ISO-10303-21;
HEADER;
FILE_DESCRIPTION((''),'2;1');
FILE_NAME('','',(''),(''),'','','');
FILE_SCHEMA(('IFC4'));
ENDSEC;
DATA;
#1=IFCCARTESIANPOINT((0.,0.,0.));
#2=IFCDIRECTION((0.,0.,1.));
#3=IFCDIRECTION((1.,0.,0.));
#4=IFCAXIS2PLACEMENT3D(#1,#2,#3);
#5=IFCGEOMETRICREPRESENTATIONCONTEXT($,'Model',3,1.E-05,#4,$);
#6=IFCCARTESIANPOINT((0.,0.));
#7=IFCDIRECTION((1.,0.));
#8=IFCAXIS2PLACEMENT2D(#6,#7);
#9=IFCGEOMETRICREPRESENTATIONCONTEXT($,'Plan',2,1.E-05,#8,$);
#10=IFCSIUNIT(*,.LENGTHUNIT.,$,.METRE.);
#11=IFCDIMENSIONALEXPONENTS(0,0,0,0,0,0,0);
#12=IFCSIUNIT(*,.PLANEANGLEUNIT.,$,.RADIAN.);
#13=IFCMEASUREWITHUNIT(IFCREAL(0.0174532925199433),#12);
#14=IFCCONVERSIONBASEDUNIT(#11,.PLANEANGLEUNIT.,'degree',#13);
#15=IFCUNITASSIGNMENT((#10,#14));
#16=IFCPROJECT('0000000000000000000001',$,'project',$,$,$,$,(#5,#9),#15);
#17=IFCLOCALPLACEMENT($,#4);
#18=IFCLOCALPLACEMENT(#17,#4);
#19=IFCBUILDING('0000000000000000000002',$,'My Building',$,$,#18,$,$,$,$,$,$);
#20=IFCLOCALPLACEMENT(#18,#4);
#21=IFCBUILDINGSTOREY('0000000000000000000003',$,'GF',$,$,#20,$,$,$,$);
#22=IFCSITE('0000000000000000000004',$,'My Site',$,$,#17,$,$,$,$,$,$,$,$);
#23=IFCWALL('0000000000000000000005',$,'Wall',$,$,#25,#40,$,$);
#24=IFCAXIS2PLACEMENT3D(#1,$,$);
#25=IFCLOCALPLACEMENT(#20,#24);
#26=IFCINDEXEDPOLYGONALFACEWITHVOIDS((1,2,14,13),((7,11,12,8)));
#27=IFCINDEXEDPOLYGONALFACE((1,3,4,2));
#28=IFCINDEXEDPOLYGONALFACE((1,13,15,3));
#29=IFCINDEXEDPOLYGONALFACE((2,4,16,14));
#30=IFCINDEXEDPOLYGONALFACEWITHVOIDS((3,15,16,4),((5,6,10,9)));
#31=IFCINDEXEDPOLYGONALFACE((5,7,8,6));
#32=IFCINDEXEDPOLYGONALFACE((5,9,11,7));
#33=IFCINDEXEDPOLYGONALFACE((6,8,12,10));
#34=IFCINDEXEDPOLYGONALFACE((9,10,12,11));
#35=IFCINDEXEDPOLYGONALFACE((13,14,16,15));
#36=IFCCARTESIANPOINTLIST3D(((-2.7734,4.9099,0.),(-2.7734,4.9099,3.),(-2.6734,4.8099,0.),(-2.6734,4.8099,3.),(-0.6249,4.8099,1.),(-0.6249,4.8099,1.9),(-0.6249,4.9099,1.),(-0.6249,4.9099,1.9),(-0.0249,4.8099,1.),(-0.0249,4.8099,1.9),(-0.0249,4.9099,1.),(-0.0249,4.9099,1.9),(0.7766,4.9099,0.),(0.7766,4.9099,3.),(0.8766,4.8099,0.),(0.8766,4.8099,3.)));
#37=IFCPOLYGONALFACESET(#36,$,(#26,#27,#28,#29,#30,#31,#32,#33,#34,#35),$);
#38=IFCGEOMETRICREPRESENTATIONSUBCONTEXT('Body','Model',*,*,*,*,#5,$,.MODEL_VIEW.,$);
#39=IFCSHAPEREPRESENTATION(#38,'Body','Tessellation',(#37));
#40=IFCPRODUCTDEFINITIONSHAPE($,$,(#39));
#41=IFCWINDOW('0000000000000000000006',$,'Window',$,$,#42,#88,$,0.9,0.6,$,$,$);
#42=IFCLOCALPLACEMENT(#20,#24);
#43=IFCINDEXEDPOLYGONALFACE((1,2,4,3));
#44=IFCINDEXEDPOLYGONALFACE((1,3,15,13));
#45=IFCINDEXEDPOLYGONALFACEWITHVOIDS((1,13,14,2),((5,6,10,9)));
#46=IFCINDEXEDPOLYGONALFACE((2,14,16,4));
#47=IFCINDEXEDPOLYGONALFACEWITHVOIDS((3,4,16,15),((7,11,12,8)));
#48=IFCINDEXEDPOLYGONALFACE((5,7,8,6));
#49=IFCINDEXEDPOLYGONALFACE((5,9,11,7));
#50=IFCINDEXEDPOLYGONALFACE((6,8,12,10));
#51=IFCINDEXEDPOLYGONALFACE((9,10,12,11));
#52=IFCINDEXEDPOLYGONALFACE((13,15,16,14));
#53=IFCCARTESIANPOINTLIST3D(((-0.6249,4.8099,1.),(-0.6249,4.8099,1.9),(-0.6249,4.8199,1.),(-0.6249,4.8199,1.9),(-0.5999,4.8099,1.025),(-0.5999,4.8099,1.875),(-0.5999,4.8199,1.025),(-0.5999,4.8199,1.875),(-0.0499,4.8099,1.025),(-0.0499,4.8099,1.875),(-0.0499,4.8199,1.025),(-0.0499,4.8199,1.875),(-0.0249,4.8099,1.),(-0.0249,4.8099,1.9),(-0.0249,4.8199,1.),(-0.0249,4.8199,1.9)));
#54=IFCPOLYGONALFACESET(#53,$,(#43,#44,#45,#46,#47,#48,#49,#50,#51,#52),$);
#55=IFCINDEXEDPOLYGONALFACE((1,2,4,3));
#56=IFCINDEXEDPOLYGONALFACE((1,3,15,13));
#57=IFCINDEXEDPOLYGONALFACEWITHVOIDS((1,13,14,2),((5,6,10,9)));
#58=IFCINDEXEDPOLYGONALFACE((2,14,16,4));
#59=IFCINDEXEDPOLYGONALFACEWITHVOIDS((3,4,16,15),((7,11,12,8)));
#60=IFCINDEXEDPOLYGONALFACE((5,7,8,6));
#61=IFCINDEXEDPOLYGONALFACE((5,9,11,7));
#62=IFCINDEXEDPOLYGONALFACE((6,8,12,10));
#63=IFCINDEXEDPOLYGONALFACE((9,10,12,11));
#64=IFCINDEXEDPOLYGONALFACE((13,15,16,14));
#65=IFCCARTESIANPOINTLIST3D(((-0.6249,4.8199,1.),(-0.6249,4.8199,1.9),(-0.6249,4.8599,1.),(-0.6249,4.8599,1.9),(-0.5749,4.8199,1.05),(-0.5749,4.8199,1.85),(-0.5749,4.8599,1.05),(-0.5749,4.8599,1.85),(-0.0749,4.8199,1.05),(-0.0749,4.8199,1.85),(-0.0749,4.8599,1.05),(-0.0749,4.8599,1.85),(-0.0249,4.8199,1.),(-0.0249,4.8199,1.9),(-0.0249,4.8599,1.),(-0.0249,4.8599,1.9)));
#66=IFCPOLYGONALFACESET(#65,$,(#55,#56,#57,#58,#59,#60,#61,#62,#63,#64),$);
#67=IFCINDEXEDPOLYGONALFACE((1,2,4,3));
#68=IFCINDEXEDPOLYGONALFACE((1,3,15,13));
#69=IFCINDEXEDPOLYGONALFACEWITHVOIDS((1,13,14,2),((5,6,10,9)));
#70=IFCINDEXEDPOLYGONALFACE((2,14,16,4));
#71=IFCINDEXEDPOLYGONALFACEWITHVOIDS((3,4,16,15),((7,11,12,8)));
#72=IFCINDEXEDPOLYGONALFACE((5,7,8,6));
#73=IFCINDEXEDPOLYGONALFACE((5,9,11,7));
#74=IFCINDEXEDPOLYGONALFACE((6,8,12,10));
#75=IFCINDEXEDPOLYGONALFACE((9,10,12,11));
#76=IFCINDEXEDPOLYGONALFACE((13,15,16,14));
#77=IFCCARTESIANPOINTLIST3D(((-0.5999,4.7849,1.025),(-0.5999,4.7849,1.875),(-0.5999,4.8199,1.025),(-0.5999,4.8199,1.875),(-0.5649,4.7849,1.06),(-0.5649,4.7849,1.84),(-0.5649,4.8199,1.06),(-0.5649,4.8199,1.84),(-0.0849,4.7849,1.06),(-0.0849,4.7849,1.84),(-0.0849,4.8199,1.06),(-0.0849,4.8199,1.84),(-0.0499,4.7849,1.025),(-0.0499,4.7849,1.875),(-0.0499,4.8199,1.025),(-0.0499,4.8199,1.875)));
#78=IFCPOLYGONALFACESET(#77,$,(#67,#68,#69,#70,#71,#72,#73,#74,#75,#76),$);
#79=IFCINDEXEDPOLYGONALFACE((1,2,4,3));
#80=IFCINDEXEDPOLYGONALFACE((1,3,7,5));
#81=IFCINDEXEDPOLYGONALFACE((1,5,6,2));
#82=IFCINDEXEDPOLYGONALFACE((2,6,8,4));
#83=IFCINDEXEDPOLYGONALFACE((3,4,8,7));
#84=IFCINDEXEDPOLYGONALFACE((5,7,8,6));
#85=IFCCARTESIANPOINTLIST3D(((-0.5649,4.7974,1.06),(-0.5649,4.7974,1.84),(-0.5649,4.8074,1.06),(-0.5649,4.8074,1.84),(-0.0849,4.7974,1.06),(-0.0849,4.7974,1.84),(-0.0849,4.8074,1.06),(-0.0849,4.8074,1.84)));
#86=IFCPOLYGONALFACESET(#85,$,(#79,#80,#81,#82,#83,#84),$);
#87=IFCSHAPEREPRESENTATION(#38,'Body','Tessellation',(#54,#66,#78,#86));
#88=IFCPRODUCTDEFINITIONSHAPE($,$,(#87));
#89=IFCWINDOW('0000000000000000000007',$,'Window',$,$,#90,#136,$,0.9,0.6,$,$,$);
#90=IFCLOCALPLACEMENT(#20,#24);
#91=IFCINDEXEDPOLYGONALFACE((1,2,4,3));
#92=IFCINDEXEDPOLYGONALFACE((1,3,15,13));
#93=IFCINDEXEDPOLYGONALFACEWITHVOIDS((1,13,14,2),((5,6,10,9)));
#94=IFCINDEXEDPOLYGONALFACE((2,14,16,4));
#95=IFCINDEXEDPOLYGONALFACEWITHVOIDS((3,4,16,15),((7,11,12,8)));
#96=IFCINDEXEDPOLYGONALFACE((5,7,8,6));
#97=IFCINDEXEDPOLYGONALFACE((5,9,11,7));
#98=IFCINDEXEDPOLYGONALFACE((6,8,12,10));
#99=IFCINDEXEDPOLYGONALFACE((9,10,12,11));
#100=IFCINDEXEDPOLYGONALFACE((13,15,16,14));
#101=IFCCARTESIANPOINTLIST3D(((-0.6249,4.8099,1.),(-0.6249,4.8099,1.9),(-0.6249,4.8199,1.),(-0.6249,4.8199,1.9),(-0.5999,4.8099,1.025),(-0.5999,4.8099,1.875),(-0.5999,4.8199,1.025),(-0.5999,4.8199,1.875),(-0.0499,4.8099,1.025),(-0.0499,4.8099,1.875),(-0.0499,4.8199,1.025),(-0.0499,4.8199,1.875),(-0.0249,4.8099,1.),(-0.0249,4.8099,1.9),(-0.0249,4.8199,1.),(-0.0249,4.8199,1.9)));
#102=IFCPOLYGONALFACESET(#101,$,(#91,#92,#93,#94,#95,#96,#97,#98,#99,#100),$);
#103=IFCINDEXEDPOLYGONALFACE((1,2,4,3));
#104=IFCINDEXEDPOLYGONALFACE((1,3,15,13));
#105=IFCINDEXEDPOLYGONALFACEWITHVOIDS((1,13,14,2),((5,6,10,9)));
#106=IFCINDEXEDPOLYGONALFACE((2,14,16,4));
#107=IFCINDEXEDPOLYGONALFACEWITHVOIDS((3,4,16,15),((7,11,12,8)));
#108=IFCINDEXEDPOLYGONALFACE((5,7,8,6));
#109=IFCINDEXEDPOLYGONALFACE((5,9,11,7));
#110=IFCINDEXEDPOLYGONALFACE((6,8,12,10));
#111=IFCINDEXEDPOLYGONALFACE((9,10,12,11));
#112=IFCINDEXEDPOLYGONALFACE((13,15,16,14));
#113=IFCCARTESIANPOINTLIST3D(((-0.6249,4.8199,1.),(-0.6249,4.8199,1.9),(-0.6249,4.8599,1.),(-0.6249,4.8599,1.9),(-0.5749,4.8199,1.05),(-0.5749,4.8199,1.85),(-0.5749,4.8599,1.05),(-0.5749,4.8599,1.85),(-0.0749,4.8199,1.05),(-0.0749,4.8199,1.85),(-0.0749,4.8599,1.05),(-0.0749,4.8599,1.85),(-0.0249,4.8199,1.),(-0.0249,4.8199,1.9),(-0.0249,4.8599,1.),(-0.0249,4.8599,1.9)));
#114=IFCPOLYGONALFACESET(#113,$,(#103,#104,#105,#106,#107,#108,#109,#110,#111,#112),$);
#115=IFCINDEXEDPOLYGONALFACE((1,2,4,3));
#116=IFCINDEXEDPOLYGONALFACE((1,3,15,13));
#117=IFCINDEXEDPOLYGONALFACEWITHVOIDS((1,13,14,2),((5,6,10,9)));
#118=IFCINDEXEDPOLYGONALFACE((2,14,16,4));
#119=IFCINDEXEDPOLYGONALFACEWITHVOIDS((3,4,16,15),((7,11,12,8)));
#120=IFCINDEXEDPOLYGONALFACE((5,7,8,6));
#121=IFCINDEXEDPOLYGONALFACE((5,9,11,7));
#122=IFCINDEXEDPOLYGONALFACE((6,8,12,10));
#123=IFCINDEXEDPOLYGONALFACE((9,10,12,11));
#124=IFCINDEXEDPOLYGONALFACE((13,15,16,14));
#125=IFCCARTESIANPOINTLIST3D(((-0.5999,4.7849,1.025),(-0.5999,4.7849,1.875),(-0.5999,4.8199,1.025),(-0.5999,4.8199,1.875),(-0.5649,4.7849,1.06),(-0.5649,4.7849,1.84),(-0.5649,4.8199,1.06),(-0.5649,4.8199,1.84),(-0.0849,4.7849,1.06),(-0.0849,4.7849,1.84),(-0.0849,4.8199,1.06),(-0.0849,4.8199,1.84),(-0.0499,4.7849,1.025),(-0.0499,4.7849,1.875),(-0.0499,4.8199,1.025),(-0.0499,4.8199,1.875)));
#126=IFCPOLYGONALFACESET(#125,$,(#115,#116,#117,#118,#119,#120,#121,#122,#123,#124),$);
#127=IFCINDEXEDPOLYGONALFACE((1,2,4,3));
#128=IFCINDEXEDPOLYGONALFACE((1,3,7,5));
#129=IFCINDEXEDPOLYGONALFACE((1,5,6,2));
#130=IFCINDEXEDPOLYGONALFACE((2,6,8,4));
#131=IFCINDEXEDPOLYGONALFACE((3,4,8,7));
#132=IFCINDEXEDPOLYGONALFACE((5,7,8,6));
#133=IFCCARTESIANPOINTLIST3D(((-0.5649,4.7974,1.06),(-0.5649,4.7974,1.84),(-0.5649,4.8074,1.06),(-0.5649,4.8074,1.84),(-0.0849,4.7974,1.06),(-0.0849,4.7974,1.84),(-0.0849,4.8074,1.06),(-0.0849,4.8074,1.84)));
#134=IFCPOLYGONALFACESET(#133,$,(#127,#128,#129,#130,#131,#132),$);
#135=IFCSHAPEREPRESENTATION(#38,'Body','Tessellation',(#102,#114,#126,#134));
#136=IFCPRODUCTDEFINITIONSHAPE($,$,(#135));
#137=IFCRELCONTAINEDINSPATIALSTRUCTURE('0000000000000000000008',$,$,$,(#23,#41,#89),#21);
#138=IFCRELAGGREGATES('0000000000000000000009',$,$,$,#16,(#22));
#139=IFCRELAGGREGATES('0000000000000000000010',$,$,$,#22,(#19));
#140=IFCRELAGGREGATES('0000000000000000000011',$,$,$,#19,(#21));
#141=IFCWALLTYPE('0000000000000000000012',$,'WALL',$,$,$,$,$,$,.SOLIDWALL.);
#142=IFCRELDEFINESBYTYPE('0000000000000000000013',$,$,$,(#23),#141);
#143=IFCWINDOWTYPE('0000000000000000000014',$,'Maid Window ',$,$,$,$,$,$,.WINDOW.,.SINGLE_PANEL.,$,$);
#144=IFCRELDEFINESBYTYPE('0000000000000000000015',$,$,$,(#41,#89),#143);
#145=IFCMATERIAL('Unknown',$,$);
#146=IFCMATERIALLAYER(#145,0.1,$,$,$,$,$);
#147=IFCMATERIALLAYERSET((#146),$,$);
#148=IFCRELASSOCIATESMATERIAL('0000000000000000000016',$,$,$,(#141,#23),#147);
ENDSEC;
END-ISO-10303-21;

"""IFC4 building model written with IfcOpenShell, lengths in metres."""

from ifc_helpers import new_model, entity, si_unit, converted_unit, frame, origin_with_axes, origin_2d_with_axis, place, context, subcontext, project, spatial, line, indexed_curve, outline, extrude, shape, source, transform, mapped, material, layer, layer_set, layer_usage, type_object, type_shapes, element, fill, save


model = new_model("IFC4")

# Units and contexts
model_context = context("Model", 3, precision=1e-05, world=origin_with_axes())
plan_context = context("Plan", 2, precision=1e-05, world=origin_2d_with_axis())
body_context_1 = subcontext(model_context, "Body", "Model", "MODEL_VIEW")
body_context_2 = subcontext(plan_context, "Body", "Plan", "PLAN_VIEW")
ifc_project = project(units=[si_unit("LENGTHUNIT", "METRE"), converted_unit("PLANEANGLEUNIT", "degree", entity("IfcReal", 0.0174532925199433), si_unit("PLANEANGLEUNIT", "RADIAN"), dimensions=[0, 0, 0, 0, 0, 0, 0])], contexts=[model_context, plan_context])

# Site, building, storey
site_placement = place(None, origin_with_axes())
site = spatial("IfcSite", under=ifc_project, at=site_placement, Name="My Site")
building_placement = place(site_placement, origin_with_axes())
building = spatial("IfcBuilding", under=site, at=building_placement, Name="My Building")
storey_placement = place(building_placement, origin_with_axes())
storey = spatial("IfcBuildingStorey", under=building, at=storey_placement, Name="GF")

# Shared definitions
ifc_material_1 = material(Name="Unknown")

# Shared definitions
ifc_layer_1 = layer(ifc_material_1, 0.1)
ifc_layer_set_1 = layer_set([ifc_layer_1])
wall_type = type_object("IfcWallType", Name="WALL", PredefinedType="SOLIDWALL", material=ifc_layer_set_1)

# Wall, openings, windows
ifc_layer_usage_1 = layer_usage(ifc_layer_set_1, "AXIS2", "POSITIVE", 0.0)
wall_1_placement = place(storey_placement, frame((0.7766, 4.9099, 0.0), z_axis=(0.0, 0.0, 1.0), x_axis=(-1.0, 0.0, 0.0)))
wall_1 = element("IfcWall", 1, at=wall_1_placement, inside=storey, type_object=wall_type, material=ifc_layer_usage_1, Name="Wall", context=body_context_1, shape_type="SweptSolid", body=[
    extrude(outline(indexed_curve([(0.0, 0.0), (-0.1, 0.1), (3.45, 0.1), (3.55, 0.0)], segments=[line(1, 2, 3, 4, 1)])), origin_with_axes(), (0.0, 0.0, 1.0), 3.0),
])
shared_shape_1 = source(origin_with_axes(), body_context_1, "Body", "SweptSolid", [
    extrude(outline(indexed_curve([(0.0, 0.0), (0.6, 0.0), (0.6, 0.9), (0.0, 0.9)], segments=[line(1, 2, 3, 4, 1)])), frame((0.0, -0.6, 0.0), z_axis=(0.0, -1.0, 0.0), x_axis=(1.0, 0.0, 0.0)), (0.0, 0.0, -1.0), 1.2),
])
opening_1_placement = place(wall_1_placement, frame((0.8015, 0.0, 1.0), z_axis=(0.0, 0.0, 1.0), x_axis=(1.0, 0.0, 0.0)))
opening_1 = element("IfcOpeningElement", 2, at=opening_1_placement, cuts=wall_1, PredefinedType="OPENING", context=body_context_1, shape_type="MappedRepresentation", body=[
    mapped(shared_shape_1, transform((0.0, 0.0, 0.0), x_axis=(1.0, 0.0, 0.0), y_axis=(0.0, 1.0, 0.0), z_axis=(0.0, 0.0, 1.0), scale=1.0)),
])
opening_2_placement = place(wall_1_placement, frame((0.8015, 0.0, 1.0), z_axis=(0.0, 0.0, 1.0), x_axis=(1.0, 0.0, 0.0)))
opening_2 = element("IfcOpeningElement", 3, at=opening_2_placement, cuts=wall_1, PredefinedType="OPENING", context=body_context_1, shape_type="MappedRepresentation", body=[
    mapped(shared_shape_1, transform((0.0, 0.0, 0.0), x_axis=(1.0, 0.0, 0.0), y_axis=(0.0, 1.0, 0.0), z_axis=(0.0, 0.0, 1.0), scale=1.0)),
])
window_type_1 = type_object("IfcWindowType", Name="Maid Window ", PartitioningType="SINGLE_PANEL", PredefinedType="WINDOW")
shared_shape_2 = source(origin_with_axes(), body_context_1, "Body", "SweptSolid", [
    extrude(outline(indexed_curve([(0.0, 0.0), (0.6, 0.0), (0.6, 0.9), (0.0, 0.9)], segments=[line(1, 2, 3, 4, 1)]), holes=[indexed_curve([(0.025, 0.025), (0.575, 0.025), (0.575, 0.875), (0.025, 0.875)], segments=[line(1, 2, 3, 4, 1)])]), frame((0.0, 0.09, 0.0), z_axis=(0.0, -1.0, 0.0), x_axis=(1.0, 0.0, 0.0)), (0.0, 0.0, -1.0), 0.01),
    extrude(outline(indexed_curve([(0.0, 0.0), (0.6, 0.0), (0.6, 0.9), (0.0, 0.9)], segments=[line(1, 2, 3, 4, 1)]), holes=[indexed_curve([(0.05, 0.05), (0.55, 0.05), (0.55, 0.85), (0.05, 0.85)], segments=[line(1, 2, 3, 4, 1)])]), frame((0.0, 0.05, 0.0), z_axis=(0.0, -1.0, 0.0), x_axis=(1.0, 0.0, 0.0)), (0.0, 0.0, -1.0), 0.04),
    extrude(outline(indexed_curve([(0.0, 0.0), (0.55, 0.0), (0.55, 0.85), (0.0, 0.85)], segments=[line(1, 2, 3, 4, 1)]), holes=[indexed_curve([(0.035, 0.035), (0.515, 0.035), (0.515, 0.815), (0.035, 0.815)], segments=[line(1, 2, 3, 4, 1)])]), frame((0.025, 0.09, 0.025), z_axis=(0.0, -1.0, 0.0), x_axis=(1.0, 0.0, 0.0)), (0.0, 0.0, -1.0), 0.035),
    extrude(outline(indexed_curve([(0.035, 0.035), (0.515, 0.035), (0.515, 0.815), (0.035, 0.815)], segments=[line(1, 2, 3, 4, 1)])), frame((0.025, 0.1025, 0.025), z_axis=(0.0, -1.0, 0.0), x_axis=(1.0, 0.0, 0.0)), (0.0, 0.0, -1.0), 0.01),
])
shared_shape_3 = source(origin_with_axes(), body_context_2, "Body", "Curve2D", [
    entity("IfcIndexedPolyCurve", entity("IfcCartesianPointList2D", [[0.05, 0.05], [0.55, 0.05]])),
    entity("IfcIndexedPolyCurve", entity("IfcCartesianPointList2D", [[0.0, 0.1], [0.025, 0.1], [0.025, 0.09], [0.05, 0.09], [0.05, 0.05], [0.0, 0.05]]), [entity("IfcLineIndex", [1, 2, 3, 4, 5, 6, 1])]),
    entity("IfcIndexedPolyCurve", entity("IfcCartesianPointList2D", [[0.6, 0.1], [0.575, 0.1], [0.575, 0.09], [0.55, 0.09], [0.55, 0.05], [0.6, 0.05]]), [entity("IfcLineIndex", [1, 2, 3, 4, 5, 6, 1])]),
    entity("IfcIndexedPolyCurve", entity("IfcCartesianPointList2D", [[0.025, 0.09], [0.06, 0.09], [0.06, 0.125], [0.025, 0.125]]), [entity("IfcLineIndex", [1, 2, 3, 4, 1])]),
    entity("IfcIndexedPolyCurve", entity("IfcCartesianPointList2D", [[0.575, 0.09], [0.54, 0.09], [0.54, 0.125], [0.575, 0.125]]), [entity("IfcLineIndex", [1, 2, 3, 4, 1])]),
    entity("IfcIndexedPolyCurve", entity("IfcCartesianPointList2D", [[0.06, 0.09], [0.54, 0.09]])),
    entity("IfcIndexedPolyCurve", entity("IfcCartesianPointList2D", [[0.06, 0.125], [0.54, 0.125]])),
    entity("IfcIndexedPolyCurve", entity("IfcCartesianPointList2D", [[0.06, 0.1075], [0.54, 0.1075]])),
])
type_shapes(window_type_1, [shared_shape_2, shared_shape_3])
window_1_placement = place(opening_1_placement, frame((0.0, 0.0, 0.0), z_axis=(0.0, 0.0, 1.0), x_axis=(1.0, 0.0, 0.0)))
window_1 = element("IfcWindow", 4, at=window_1_placement, inside=storey, type_object=window_type_1, Name="Window", OverallHeight=0.9, OverallWidth=0.6, shapes=[
    shape(body_context_1, "Body", "MappedRepresentation", [mapped(shared_shape_2, transform((0.0, 0.0, 0.0), x_axis=(1.0, 0.0, 0.0), y_axis=(0.0, 1.0, 0.0), z_axis=(0.0, 0.0, 1.0), scale=1.0))]),
    shape(body_context_2, "Body", "MappedRepresentation", [mapped(shared_shape_3, transform((0.0, 0.0, 0.0), x_axis=(1.0, 0.0, 0.0), y_axis=(0.0, 1.0, 0.0), z_axis=(0.0, 0.0, 1.0), scale=1.0))]),
])
fill(opening_1, window_1)
window_2_placement = place(opening_2_placement, frame((0.0, 0.0, 0.0), z_axis=(0.0, 0.0, 1.0), x_axis=(1.0, 0.0, 0.0)))
window_2 = element("IfcWindow", 5, at=window_2_placement, inside=storey, type_object=window_type_1, Name="Window", OverallHeight=0.9, OverallWidth=0.6, shapes=[
    shape(body_context_1, "Body", "MappedRepresentation", [mapped(shared_shape_2, transform((0.0, 0.0, 0.0), x_axis=(1.0, 0.0, 0.0), y_axis=(0.0, 1.0, 0.0), z_axis=(0.0, 0.0, 1.0), scale=1.0))]),
    shape(body_context_2, "Body", "MappedRepresentation", [mapped(shared_shape_3, transform((0.0, 0.0, 0.0), x_axis=(1.0, 0.0, 0.0), y_axis=(0.0, 1.0, 0.0), z_axis=(0.0, 0.0, 1.0), scale=1.0))]),
])
fill(opening_2, window_2)

save(model, "model.ifc")
